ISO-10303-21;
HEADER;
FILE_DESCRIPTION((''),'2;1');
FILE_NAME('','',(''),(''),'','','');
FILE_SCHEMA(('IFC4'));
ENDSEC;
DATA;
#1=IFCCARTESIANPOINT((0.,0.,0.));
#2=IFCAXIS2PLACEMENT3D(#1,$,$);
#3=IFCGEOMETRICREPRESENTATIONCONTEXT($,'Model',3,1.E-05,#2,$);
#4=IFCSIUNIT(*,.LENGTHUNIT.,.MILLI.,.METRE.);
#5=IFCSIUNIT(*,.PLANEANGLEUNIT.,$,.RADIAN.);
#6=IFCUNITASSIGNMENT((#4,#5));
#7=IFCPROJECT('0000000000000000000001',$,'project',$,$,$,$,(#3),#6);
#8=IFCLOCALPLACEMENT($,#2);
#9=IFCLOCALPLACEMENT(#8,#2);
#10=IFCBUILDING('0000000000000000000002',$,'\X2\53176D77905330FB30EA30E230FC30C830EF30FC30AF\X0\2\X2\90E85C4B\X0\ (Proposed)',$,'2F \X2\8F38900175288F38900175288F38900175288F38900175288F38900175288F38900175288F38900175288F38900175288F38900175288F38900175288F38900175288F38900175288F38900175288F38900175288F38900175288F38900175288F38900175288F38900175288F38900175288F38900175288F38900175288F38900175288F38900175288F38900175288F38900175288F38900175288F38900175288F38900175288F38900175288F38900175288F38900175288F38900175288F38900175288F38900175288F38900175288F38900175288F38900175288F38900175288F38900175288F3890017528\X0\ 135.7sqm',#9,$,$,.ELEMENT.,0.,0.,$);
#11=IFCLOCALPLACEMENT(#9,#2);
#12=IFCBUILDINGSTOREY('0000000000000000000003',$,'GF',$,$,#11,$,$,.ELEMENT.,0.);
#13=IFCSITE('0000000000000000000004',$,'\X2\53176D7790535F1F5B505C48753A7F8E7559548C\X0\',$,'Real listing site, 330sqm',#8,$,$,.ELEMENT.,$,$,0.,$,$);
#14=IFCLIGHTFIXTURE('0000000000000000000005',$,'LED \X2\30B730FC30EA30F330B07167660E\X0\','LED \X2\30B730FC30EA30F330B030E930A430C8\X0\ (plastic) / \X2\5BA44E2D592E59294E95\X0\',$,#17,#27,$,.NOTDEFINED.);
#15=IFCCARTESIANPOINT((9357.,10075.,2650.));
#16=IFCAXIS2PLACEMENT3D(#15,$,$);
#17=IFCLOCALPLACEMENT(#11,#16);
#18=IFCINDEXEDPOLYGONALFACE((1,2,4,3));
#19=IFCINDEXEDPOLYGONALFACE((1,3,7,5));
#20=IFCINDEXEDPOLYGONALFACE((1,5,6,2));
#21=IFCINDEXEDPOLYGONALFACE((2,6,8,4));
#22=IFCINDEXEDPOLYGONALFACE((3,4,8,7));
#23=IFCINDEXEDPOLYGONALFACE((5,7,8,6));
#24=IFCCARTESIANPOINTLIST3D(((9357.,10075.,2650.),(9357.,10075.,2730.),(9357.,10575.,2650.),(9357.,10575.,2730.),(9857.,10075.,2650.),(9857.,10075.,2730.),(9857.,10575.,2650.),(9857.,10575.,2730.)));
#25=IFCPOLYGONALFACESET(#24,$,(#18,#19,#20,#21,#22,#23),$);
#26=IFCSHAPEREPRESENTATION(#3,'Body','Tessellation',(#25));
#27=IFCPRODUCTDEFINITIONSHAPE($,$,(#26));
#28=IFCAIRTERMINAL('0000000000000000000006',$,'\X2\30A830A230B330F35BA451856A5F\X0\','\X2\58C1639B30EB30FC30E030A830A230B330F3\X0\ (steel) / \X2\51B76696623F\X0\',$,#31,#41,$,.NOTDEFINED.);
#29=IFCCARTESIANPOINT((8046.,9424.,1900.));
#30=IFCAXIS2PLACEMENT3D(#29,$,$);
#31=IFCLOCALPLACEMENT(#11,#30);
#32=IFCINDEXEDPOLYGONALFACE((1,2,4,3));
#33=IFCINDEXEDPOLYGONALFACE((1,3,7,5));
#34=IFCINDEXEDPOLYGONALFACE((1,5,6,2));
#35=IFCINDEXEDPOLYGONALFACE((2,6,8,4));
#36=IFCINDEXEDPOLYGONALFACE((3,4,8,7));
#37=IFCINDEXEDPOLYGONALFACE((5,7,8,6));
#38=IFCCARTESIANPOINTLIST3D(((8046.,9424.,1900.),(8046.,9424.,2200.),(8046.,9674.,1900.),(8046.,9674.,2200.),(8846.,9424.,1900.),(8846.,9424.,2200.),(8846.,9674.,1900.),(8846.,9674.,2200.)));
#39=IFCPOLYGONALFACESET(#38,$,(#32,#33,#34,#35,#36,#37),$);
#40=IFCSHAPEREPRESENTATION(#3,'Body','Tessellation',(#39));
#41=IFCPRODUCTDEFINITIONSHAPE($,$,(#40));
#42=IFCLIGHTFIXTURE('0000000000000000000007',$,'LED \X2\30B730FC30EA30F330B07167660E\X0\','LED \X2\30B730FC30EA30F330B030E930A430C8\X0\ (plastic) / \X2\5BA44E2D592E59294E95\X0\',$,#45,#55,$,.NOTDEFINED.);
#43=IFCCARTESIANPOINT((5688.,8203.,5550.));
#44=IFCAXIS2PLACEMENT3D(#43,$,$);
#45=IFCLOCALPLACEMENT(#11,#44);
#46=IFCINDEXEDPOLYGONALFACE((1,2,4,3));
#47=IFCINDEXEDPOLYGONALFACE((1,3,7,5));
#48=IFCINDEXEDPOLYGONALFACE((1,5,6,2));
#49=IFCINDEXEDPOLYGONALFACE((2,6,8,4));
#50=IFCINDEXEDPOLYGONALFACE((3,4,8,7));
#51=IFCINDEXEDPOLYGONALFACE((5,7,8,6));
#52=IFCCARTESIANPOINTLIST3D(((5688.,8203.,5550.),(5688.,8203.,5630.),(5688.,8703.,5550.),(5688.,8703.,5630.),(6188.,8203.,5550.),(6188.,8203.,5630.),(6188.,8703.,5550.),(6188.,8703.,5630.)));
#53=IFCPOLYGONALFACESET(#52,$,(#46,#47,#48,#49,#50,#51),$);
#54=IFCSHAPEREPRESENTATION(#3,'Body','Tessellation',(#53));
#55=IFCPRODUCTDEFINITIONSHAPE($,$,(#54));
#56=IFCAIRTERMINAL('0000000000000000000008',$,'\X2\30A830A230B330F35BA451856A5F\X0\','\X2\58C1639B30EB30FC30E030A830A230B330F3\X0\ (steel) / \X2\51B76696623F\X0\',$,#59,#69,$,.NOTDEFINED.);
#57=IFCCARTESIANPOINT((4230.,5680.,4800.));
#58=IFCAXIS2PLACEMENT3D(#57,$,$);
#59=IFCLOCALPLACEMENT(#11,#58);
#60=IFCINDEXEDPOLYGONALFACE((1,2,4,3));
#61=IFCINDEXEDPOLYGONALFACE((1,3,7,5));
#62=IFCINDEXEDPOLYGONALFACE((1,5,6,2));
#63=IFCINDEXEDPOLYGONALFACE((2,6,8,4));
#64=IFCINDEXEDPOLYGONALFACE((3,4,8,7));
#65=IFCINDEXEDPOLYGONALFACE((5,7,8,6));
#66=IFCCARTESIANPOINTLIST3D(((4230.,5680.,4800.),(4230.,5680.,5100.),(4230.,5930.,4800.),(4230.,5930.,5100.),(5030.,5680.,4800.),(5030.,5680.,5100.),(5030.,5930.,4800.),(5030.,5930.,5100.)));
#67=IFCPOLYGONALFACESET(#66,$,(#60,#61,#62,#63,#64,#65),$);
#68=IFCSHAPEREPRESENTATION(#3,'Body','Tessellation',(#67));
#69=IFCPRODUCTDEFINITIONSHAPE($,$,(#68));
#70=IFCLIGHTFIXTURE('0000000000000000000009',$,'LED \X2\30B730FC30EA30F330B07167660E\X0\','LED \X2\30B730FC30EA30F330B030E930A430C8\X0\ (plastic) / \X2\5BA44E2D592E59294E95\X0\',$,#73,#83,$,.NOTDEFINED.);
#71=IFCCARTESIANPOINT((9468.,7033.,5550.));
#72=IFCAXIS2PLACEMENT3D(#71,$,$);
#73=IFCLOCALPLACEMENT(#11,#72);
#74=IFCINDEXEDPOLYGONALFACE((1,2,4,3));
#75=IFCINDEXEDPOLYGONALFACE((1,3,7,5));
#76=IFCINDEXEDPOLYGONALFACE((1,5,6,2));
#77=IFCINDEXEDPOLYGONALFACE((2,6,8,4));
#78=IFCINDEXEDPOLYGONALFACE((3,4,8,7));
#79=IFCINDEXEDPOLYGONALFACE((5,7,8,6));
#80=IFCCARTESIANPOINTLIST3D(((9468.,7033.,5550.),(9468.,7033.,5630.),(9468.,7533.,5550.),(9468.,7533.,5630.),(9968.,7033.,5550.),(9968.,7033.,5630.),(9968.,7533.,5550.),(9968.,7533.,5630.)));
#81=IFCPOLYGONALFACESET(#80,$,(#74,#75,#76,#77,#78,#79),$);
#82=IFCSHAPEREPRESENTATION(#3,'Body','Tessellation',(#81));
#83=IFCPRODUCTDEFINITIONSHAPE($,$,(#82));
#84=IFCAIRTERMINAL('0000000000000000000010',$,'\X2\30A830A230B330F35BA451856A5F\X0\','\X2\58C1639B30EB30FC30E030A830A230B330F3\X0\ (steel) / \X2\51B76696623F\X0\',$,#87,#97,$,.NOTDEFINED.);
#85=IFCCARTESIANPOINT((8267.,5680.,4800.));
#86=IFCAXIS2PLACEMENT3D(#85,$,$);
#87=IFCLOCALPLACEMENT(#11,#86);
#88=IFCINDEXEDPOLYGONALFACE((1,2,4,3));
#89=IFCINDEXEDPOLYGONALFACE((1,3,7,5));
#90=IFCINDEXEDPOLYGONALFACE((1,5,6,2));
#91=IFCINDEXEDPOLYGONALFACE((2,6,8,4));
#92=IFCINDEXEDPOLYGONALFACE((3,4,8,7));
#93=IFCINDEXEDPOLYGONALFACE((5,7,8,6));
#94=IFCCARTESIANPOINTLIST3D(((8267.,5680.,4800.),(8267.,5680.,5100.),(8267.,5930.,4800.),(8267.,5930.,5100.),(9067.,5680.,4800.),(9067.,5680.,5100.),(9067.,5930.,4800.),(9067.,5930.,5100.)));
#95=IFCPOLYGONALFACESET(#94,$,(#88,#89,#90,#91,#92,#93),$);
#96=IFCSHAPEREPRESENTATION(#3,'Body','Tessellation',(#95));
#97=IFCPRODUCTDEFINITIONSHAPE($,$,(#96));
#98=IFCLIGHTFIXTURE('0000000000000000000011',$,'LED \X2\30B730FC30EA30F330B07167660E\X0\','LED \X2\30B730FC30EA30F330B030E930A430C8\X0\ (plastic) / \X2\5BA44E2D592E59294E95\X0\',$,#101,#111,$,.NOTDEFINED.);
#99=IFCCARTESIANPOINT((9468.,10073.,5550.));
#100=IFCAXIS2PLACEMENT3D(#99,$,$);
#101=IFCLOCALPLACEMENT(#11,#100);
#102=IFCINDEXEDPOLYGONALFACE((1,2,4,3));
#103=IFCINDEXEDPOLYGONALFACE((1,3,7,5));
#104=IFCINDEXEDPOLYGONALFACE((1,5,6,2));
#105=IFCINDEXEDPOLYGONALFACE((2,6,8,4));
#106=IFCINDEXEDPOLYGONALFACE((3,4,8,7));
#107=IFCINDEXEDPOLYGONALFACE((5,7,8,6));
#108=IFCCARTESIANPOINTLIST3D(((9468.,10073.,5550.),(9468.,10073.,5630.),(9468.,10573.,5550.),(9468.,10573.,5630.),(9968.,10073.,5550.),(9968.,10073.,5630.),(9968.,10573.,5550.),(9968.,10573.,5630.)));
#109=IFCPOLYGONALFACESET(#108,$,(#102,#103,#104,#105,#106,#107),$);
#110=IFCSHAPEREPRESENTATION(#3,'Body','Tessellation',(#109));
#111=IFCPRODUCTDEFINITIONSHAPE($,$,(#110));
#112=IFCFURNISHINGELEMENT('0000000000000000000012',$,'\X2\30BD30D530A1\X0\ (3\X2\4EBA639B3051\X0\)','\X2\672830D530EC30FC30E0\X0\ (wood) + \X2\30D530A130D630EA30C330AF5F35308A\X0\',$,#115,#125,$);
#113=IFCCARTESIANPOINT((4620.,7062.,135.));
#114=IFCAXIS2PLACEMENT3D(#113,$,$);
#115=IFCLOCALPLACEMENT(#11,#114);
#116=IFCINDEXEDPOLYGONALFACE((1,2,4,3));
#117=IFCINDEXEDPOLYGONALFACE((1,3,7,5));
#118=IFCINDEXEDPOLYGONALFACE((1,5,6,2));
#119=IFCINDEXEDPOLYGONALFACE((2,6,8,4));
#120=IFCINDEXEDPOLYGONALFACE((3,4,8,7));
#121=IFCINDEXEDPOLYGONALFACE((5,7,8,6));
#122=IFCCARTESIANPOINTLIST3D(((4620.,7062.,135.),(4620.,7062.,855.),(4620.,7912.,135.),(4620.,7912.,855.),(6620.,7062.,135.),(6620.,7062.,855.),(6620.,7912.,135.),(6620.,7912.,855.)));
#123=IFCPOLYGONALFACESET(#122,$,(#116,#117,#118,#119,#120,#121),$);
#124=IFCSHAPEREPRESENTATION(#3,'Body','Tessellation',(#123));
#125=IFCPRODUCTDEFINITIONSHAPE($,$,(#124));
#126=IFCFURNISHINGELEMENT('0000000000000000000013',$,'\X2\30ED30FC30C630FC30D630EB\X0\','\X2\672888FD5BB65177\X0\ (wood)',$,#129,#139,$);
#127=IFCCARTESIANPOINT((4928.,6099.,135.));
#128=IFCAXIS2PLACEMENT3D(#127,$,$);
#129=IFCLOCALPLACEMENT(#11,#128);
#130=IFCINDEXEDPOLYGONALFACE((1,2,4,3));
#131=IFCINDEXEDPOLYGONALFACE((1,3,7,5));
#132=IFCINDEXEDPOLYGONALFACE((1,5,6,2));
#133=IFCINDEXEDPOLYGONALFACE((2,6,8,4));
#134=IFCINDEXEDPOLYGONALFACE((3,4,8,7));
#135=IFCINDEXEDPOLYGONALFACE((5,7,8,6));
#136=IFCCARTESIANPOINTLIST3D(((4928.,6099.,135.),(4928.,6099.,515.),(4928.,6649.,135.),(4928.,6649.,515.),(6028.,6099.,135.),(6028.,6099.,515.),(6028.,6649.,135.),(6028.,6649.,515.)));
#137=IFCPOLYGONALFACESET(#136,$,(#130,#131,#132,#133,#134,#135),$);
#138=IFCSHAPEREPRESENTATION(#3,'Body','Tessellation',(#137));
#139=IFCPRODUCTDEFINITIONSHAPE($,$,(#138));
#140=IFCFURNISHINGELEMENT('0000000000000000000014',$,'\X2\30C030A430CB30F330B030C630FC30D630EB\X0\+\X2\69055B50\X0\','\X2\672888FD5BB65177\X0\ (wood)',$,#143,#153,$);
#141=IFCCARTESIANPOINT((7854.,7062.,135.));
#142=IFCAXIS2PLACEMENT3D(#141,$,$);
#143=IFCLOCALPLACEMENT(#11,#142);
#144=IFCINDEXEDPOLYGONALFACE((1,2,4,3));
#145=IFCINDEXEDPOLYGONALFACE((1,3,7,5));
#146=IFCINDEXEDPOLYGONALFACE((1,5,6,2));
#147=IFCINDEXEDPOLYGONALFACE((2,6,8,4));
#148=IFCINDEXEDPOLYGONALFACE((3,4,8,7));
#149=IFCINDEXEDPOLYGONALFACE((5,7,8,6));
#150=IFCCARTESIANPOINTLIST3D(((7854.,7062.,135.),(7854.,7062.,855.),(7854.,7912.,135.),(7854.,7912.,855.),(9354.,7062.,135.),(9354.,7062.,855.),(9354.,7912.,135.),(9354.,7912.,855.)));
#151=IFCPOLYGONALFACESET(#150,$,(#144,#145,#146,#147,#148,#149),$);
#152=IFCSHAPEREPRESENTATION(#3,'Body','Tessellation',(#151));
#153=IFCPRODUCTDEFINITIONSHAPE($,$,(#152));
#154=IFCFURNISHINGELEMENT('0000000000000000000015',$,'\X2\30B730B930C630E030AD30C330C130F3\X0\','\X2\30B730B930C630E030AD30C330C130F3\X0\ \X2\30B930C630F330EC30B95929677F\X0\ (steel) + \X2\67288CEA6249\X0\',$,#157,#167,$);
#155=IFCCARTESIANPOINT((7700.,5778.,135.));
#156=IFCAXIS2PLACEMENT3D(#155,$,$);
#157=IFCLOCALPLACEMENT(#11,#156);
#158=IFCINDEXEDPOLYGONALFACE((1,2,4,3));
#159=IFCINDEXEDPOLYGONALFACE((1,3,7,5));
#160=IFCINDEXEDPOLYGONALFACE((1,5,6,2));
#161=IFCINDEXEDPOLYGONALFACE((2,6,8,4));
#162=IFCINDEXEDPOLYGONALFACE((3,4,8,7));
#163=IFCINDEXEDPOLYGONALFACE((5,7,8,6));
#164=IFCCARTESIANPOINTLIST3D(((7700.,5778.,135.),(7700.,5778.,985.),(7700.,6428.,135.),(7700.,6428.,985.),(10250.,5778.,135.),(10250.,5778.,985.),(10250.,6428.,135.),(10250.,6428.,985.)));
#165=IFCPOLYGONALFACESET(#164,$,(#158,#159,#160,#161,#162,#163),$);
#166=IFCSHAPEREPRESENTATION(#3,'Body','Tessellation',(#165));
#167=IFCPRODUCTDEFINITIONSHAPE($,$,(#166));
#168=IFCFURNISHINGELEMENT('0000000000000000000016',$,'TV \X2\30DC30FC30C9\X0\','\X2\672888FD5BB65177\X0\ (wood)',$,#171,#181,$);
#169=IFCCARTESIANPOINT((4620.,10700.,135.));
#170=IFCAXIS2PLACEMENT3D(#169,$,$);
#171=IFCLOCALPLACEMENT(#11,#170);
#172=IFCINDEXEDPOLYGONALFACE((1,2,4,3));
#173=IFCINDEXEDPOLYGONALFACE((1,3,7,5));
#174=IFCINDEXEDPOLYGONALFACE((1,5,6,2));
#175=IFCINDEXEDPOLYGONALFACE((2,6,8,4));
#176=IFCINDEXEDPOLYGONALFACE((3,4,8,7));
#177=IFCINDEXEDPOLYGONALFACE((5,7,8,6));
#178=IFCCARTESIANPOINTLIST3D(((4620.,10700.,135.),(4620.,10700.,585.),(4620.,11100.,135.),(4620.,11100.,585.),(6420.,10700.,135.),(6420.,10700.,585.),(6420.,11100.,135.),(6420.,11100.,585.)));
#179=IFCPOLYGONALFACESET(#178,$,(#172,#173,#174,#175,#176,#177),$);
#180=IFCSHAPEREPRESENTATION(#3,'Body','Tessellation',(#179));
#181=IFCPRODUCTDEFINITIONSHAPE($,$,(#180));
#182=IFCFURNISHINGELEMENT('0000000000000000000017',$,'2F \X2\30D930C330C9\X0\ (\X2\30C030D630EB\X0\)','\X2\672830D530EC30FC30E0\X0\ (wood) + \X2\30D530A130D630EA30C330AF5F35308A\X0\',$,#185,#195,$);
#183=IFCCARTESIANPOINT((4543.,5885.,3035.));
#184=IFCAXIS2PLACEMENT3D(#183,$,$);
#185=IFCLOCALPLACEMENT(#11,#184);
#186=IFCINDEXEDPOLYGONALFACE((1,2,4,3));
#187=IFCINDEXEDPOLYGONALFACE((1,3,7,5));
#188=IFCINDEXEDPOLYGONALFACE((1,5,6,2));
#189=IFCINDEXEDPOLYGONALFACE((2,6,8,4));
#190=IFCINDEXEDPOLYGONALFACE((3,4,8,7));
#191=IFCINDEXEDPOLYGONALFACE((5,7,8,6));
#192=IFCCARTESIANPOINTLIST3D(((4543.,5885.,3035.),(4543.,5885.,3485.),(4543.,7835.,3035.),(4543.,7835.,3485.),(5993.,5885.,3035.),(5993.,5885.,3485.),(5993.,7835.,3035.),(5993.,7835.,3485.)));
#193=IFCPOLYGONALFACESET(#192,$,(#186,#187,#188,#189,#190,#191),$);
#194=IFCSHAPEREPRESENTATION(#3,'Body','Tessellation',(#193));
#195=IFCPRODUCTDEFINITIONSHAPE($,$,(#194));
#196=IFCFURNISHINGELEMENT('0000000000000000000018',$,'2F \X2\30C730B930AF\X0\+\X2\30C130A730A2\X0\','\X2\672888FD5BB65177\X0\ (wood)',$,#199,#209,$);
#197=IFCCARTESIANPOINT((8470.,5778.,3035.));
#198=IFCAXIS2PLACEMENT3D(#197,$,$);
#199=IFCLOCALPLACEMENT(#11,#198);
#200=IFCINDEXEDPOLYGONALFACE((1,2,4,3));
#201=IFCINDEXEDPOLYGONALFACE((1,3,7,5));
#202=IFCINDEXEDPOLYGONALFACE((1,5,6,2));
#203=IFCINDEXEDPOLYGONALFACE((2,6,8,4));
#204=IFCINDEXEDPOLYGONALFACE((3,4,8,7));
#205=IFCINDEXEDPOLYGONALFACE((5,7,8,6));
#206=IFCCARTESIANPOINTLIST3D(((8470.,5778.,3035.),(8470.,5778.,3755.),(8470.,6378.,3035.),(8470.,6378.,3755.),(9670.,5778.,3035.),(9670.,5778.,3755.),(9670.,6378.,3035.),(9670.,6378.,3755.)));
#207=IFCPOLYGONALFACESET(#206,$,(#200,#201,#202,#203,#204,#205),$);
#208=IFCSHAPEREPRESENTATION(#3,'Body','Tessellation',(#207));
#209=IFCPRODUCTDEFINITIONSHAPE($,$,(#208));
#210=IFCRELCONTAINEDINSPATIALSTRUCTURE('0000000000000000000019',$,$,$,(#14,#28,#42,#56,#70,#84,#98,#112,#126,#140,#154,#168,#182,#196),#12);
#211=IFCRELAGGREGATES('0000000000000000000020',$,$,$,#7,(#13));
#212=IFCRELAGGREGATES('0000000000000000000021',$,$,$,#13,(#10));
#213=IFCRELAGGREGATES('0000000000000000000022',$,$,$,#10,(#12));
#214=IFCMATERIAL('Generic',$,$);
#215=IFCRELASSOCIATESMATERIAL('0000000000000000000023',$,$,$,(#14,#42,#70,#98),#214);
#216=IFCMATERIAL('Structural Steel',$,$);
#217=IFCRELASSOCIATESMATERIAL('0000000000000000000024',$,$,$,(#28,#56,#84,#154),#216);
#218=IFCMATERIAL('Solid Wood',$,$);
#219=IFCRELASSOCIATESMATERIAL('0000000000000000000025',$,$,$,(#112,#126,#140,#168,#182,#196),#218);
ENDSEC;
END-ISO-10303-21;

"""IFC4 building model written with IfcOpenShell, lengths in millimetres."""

from ifc_helpers import new_model, si_unit, frame, frame_2d, origin, place, context, project, spatial, rectangle, extrude, material, element, save


model = new_model("IFC4")

# Units and contexts
model_context = context("Model", 3, precision=1e-05, world=origin())
ifc_project = project(units=[si_unit("LENGTHUNIT", "METRE", prefix="MILLI"), si_unit("PLANEANGLEUNIT", "RADIAN")], contexts=[model_context])

# Site, building, storey
site_placement = place(None, origin())
site = spatial("IfcSite", under=ifc_project, at=site_placement, Name="北海道弟子屈町美留和", ObjectType="Real listing site, 330sqm", CompositionType="ELEMENT", RefElevation=0.0)
building_placement = place(site_placement, origin())
building = spatial("IfcBuilding", under=site, at=building_placement, Name="北海道・リモートワーク2部屋 (Proposed)", ObjectType="2F 輸送用輸送用輸送用輸送用輸送用輸送用輸送用輸送用輸送用輸送用輸送用輸送用輸送用輸送用輸送用輸送用輸送用輸送用輸送用輸送用輸送用輸送用輸送用輸送用輸送用輸送用輸送用輸送用輸送用輸送用輸送用輸送用輸送用輸送用輸送用輸送用輸送用輸送用輸送用輸送用 135.7sqm", CompositionType="ELEMENT", ElevationOfRefHeight=0.0, ElevationOfTerrain=0.0)
storey_placement = place(building_placement, origin())
storey = spatial("IfcBuildingStorey", under=building, at=storey_placement, Name="GF", CompositionType="ELEMENT", Elevation=0.0)

# Shared definitions
ifc_material_1 = material(Name="Solid Wood")

# Shared definitions
ifc_material_2 = material(Name="Structural Steel")

# Shared definitions
ifc_material_3 = material(Name="Generic")

# Light fixture
light_fixture_1_placement = place(storey_placement, frame((9357.0, 10075.0, 2650.0)))
element("IfcLightFixture", 1, at=light_fixture_1_placement, inside=storey, material=ifc_material_3, Name="LED シーリング照明", Description="LED シーリングライト (plastic) / 室中央天井", PredefinedType="NOTDEFINED", context=model_context, shape_type="SweptSolid", body=[
    extrude(rectangle(XDim=500.0, YDim=500.0, at=frame_2d((250.0, 250.0))), frame((9357.0, 10075.0, 2650.0)), (0.0, 0.0, 1.0), 80.0),
])

# Air terminal
air_terminal_1_placement = place(storey_placement, frame((8046.0, 9424.0, 1900.0)))
element("IfcAirTerminal", 2, at=air_terminal_1_placement, inside=storey, material=ifc_material_2, Name="エアコン室内機", Description="壁掛ルームエアコン (steel) / 冷暖房", PredefinedType="NOTDEFINED", context=model_context, shape_type="SweptSolid", body=[
    extrude(rectangle(XDim=800.0, YDim=250.0, at=frame_2d((400.0, 125.0))), frame((8046.0, 9424.0, 1900.0)), (0.0, 0.0, 1.0), 300.0),
])

# Light fixture
light_fixture_2_placement = place(storey_placement, frame((5688.0, 8203.0, 5550.0)))
element("IfcLightFixture", 3, at=light_fixture_2_placement, inside=storey, material=ifc_material_3, Name="LED シーリング照明", Description="LED シーリングライト (plastic) / 室中央天井", PredefinedType="NOTDEFINED", context=model_context, shape_type="SweptSolid", body=[
    extrude(rectangle(XDim=500.0, YDim=500.0, at=frame_2d((250.0, 250.0))), frame((5688.0, 8203.0, 5550.0)), (0.0, 0.0, 1.0), 80.0),
])

# Air terminal
air_terminal_2_placement = place(storey_placement, frame((4230.0, 5680.0, 4800.0)))
element("IfcAirTerminal", 4, at=air_terminal_2_placement, inside=storey, material=ifc_material_2, Name="エアコン室内機", Description="壁掛ルームエアコン (steel) / 冷暖房", PredefinedType="NOTDEFINED", context=model_context, shape_type="SweptSolid", body=[
    extrude(rectangle(XDim=800.0, YDim=250.0, at=frame_2d((400.0, 125.0))), frame((4230.0, 5680.0, 4800.0)), (0.0, 0.0, 1.0), 300.0),
])

# Light fixture
light_fixture_3_placement = place(storey_placement, frame((9468.0, 7033.0, 5550.0)))
element("IfcLightFixture", 5, at=light_fixture_3_placement, inside=storey, material=ifc_material_3, Name="LED シーリング照明", Description="LED シーリングライト (plastic) / 室中央天井", PredefinedType="NOTDEFINED", context=model_context, shape_type="SweptSolid", body=[
    extrude(rectangle(XDim=500.0, YDim=500.0, at=frame_2d((250.0, 250.0))), frame((9468.0, 7033.0, 5550.0)), (0.0, 0.0, 1.0), 80.0),
])

# Air terminal
air_terminal_3_placement = place(storey_placement, frame((8267.0, 5680.0, 4800.0)))
element("IfcAirTerminal", 6, at=air_terminal_3_placement, inside=storey, material=ifc_material_2, Name="エアコン室内機", Description="壁掛ルームエアコン (steel) / 冷暖房", PredefinedType="NOTDEFINED", context=model_context, shape_type="SweptSolid", body=[
    extrude(rectangle(XDim=800.0, YDim=250.0, at=frame_2d((400.0, 125.0))), frame((8267.0, 5680.0, 4800.0)), (0.0, 0.0, 1.0), 300.0),
])

# Light fixture
light_fixture_4_placement = place(storey_placement, frame((9468.0, 10073.0, 5550.0)))
element("IfcLightFixture", 7, at=light_fixture_4_placement, inside=storey, material=ifc_material_3, Name="LED シーリング照明", Description="LED シーリングライト (plastic) / 室中央天井", PredefinedType="NOTDEFINED", context=model_context, shape_type="SweptSolid", body=[
    extrude(rectangle(XDim=500.0, YDim=500.0, at=frame_2d((250.0, 250.0))), frame((9468.0, 10073.0, 5550.0)), (0.0, 0.0, 1.0), 80.0),
])

# Furnishing elements
furnishing_1_placement = place(storey_placement, frame((4620.0, 7062.0, 135.0)))
element("IfcFurnishingElement", 8, at=furnishing_1_placement, inside=storey, material=ifc_material_1, Name="ソファ (3人掛け)", Description="木フレーム (wood) + ファブリック張り", context=model_context, shape_type="SweptSolid", body=[
    extrude(rectangle(XDim=2000.0, YDim=850.0, at=frame_2d((1000.0, 425.0))), frame((4620.0, 7062.0, 135.0)), (0.0, 0.0, 1.0), 720.0),
])
furnishing_2_placement = place(storey_placement, frame((4928.0, 6099.0, 135.0)))
element("IfcFurnishingElement", 9, at=furnishing_2_placement, inside=storey, material=ifc_material_1, Name="ローテーブル", Description="木製家具 (wood)", context=model_context, shape_type="SweptSolid", body=[
    extrude(rectangle(XDim=1100.0, YDim=550.0, at=frame_2d((550.0, 275.0))), frame((4928.0, 6099.0, 135.0)), (0.0, 0.0, 1.0), 380.0),
])
furnishing_3_placement = place(storey_placement, frame((7854.0, 7062.0, 135.0)))
element("IfcFurnishingElement", 10, at=furnishing_3_placement, inside=storey, material=ifc_material_1, Name="ダイニングテーブル+椅子", Description="木製家具 (wood)", context=model_context, shape_type="SweptSolid", body=[
    extrude(rectangle(XDim=1500.0, YDim=850.0, at=frame_2d((750.0, 425.0))), frame((7854.0, 7062.0, 135.0)), (0.0, 0.0, 1.0), 720.0),
])
furnishing_4_placement = place(storey_placement, frame((7700.0, 5778.0, 135.0)))
element("IfcFurnishingElement", 11, at=furnishing_4_placement, inside=storey, material=ifc_material_2, Name="システムキッチン", Description="システムキッチン ステンレス天板 (steel) + 木質扉", context=model_context, shape_type="SweptSolid", body=[
    extrude(rectangle(XDim=2550.0, YDim=650.0, at=frame_2d((1275.0, 325.0))), frame((7700.0, 5778.0, 135.0)), (0.0, 0.0, 1.0), 850.0),
])
furnishing_5_placement = place(storey_placement, frame((4620.0, 10700.0, 135.0)))
element("IfcFurnishingElement", 12, at=furnishing_5_placement, inside=storey, material=ifc_material_1, Name="TV ボード", Description="木製家具 (wood)", context=model_context, shape_type="SweptSolid", body=[
    extrude(rectangle(XDim=1800.0, YDim=400.0, at=frame_2d((900.0, 200.0))), frame((4620.0, 10700.0, 135.0)), (0.0, 0.0, 1.0), 450.0),
])
furnishing_6_placement = place(storey_placement, frame((4543.0, 5885.0, 3035.0)))
element("IfcFurnishingElement", 13, at=furnishing_6_placement, inside=storey, material=ifc_material_1, Name="2F ベッド (ダブル)", Description="木フレーム (wood) + ファブリック張り", context=model_context, shape_type="SweptSolid", body=[
    extrude(rectangle(XDim=1450.0, YDim=1950.0, at=frame_2d((725.0, 975.0))), frame((4543.0, 5885.0, 3035.0)), (0.0, 0.0, 1.0), 450.0),
])
furnishing_7_placement = place(storey_placement, frame((8470.0, 5778.0, 3035.0)))
element("IfcFurnishingElement", 14, at=furnishing_7_placement, inside=storey, material=ifc_material_1, Name="2F デスク+チェア", Description="木製家具 (wood)", context=model_context, shape_type="SweptSolid", body=[
    extrude(rectangle(XDim=1200.0, YDim=600.0, at=frame_2d((600.0, 300.0))), frame((8470.0, 5778.0, 3035.0)), (0.0, 0.0, 1.0), 720.0),
])

save(model, "model.ifc")
